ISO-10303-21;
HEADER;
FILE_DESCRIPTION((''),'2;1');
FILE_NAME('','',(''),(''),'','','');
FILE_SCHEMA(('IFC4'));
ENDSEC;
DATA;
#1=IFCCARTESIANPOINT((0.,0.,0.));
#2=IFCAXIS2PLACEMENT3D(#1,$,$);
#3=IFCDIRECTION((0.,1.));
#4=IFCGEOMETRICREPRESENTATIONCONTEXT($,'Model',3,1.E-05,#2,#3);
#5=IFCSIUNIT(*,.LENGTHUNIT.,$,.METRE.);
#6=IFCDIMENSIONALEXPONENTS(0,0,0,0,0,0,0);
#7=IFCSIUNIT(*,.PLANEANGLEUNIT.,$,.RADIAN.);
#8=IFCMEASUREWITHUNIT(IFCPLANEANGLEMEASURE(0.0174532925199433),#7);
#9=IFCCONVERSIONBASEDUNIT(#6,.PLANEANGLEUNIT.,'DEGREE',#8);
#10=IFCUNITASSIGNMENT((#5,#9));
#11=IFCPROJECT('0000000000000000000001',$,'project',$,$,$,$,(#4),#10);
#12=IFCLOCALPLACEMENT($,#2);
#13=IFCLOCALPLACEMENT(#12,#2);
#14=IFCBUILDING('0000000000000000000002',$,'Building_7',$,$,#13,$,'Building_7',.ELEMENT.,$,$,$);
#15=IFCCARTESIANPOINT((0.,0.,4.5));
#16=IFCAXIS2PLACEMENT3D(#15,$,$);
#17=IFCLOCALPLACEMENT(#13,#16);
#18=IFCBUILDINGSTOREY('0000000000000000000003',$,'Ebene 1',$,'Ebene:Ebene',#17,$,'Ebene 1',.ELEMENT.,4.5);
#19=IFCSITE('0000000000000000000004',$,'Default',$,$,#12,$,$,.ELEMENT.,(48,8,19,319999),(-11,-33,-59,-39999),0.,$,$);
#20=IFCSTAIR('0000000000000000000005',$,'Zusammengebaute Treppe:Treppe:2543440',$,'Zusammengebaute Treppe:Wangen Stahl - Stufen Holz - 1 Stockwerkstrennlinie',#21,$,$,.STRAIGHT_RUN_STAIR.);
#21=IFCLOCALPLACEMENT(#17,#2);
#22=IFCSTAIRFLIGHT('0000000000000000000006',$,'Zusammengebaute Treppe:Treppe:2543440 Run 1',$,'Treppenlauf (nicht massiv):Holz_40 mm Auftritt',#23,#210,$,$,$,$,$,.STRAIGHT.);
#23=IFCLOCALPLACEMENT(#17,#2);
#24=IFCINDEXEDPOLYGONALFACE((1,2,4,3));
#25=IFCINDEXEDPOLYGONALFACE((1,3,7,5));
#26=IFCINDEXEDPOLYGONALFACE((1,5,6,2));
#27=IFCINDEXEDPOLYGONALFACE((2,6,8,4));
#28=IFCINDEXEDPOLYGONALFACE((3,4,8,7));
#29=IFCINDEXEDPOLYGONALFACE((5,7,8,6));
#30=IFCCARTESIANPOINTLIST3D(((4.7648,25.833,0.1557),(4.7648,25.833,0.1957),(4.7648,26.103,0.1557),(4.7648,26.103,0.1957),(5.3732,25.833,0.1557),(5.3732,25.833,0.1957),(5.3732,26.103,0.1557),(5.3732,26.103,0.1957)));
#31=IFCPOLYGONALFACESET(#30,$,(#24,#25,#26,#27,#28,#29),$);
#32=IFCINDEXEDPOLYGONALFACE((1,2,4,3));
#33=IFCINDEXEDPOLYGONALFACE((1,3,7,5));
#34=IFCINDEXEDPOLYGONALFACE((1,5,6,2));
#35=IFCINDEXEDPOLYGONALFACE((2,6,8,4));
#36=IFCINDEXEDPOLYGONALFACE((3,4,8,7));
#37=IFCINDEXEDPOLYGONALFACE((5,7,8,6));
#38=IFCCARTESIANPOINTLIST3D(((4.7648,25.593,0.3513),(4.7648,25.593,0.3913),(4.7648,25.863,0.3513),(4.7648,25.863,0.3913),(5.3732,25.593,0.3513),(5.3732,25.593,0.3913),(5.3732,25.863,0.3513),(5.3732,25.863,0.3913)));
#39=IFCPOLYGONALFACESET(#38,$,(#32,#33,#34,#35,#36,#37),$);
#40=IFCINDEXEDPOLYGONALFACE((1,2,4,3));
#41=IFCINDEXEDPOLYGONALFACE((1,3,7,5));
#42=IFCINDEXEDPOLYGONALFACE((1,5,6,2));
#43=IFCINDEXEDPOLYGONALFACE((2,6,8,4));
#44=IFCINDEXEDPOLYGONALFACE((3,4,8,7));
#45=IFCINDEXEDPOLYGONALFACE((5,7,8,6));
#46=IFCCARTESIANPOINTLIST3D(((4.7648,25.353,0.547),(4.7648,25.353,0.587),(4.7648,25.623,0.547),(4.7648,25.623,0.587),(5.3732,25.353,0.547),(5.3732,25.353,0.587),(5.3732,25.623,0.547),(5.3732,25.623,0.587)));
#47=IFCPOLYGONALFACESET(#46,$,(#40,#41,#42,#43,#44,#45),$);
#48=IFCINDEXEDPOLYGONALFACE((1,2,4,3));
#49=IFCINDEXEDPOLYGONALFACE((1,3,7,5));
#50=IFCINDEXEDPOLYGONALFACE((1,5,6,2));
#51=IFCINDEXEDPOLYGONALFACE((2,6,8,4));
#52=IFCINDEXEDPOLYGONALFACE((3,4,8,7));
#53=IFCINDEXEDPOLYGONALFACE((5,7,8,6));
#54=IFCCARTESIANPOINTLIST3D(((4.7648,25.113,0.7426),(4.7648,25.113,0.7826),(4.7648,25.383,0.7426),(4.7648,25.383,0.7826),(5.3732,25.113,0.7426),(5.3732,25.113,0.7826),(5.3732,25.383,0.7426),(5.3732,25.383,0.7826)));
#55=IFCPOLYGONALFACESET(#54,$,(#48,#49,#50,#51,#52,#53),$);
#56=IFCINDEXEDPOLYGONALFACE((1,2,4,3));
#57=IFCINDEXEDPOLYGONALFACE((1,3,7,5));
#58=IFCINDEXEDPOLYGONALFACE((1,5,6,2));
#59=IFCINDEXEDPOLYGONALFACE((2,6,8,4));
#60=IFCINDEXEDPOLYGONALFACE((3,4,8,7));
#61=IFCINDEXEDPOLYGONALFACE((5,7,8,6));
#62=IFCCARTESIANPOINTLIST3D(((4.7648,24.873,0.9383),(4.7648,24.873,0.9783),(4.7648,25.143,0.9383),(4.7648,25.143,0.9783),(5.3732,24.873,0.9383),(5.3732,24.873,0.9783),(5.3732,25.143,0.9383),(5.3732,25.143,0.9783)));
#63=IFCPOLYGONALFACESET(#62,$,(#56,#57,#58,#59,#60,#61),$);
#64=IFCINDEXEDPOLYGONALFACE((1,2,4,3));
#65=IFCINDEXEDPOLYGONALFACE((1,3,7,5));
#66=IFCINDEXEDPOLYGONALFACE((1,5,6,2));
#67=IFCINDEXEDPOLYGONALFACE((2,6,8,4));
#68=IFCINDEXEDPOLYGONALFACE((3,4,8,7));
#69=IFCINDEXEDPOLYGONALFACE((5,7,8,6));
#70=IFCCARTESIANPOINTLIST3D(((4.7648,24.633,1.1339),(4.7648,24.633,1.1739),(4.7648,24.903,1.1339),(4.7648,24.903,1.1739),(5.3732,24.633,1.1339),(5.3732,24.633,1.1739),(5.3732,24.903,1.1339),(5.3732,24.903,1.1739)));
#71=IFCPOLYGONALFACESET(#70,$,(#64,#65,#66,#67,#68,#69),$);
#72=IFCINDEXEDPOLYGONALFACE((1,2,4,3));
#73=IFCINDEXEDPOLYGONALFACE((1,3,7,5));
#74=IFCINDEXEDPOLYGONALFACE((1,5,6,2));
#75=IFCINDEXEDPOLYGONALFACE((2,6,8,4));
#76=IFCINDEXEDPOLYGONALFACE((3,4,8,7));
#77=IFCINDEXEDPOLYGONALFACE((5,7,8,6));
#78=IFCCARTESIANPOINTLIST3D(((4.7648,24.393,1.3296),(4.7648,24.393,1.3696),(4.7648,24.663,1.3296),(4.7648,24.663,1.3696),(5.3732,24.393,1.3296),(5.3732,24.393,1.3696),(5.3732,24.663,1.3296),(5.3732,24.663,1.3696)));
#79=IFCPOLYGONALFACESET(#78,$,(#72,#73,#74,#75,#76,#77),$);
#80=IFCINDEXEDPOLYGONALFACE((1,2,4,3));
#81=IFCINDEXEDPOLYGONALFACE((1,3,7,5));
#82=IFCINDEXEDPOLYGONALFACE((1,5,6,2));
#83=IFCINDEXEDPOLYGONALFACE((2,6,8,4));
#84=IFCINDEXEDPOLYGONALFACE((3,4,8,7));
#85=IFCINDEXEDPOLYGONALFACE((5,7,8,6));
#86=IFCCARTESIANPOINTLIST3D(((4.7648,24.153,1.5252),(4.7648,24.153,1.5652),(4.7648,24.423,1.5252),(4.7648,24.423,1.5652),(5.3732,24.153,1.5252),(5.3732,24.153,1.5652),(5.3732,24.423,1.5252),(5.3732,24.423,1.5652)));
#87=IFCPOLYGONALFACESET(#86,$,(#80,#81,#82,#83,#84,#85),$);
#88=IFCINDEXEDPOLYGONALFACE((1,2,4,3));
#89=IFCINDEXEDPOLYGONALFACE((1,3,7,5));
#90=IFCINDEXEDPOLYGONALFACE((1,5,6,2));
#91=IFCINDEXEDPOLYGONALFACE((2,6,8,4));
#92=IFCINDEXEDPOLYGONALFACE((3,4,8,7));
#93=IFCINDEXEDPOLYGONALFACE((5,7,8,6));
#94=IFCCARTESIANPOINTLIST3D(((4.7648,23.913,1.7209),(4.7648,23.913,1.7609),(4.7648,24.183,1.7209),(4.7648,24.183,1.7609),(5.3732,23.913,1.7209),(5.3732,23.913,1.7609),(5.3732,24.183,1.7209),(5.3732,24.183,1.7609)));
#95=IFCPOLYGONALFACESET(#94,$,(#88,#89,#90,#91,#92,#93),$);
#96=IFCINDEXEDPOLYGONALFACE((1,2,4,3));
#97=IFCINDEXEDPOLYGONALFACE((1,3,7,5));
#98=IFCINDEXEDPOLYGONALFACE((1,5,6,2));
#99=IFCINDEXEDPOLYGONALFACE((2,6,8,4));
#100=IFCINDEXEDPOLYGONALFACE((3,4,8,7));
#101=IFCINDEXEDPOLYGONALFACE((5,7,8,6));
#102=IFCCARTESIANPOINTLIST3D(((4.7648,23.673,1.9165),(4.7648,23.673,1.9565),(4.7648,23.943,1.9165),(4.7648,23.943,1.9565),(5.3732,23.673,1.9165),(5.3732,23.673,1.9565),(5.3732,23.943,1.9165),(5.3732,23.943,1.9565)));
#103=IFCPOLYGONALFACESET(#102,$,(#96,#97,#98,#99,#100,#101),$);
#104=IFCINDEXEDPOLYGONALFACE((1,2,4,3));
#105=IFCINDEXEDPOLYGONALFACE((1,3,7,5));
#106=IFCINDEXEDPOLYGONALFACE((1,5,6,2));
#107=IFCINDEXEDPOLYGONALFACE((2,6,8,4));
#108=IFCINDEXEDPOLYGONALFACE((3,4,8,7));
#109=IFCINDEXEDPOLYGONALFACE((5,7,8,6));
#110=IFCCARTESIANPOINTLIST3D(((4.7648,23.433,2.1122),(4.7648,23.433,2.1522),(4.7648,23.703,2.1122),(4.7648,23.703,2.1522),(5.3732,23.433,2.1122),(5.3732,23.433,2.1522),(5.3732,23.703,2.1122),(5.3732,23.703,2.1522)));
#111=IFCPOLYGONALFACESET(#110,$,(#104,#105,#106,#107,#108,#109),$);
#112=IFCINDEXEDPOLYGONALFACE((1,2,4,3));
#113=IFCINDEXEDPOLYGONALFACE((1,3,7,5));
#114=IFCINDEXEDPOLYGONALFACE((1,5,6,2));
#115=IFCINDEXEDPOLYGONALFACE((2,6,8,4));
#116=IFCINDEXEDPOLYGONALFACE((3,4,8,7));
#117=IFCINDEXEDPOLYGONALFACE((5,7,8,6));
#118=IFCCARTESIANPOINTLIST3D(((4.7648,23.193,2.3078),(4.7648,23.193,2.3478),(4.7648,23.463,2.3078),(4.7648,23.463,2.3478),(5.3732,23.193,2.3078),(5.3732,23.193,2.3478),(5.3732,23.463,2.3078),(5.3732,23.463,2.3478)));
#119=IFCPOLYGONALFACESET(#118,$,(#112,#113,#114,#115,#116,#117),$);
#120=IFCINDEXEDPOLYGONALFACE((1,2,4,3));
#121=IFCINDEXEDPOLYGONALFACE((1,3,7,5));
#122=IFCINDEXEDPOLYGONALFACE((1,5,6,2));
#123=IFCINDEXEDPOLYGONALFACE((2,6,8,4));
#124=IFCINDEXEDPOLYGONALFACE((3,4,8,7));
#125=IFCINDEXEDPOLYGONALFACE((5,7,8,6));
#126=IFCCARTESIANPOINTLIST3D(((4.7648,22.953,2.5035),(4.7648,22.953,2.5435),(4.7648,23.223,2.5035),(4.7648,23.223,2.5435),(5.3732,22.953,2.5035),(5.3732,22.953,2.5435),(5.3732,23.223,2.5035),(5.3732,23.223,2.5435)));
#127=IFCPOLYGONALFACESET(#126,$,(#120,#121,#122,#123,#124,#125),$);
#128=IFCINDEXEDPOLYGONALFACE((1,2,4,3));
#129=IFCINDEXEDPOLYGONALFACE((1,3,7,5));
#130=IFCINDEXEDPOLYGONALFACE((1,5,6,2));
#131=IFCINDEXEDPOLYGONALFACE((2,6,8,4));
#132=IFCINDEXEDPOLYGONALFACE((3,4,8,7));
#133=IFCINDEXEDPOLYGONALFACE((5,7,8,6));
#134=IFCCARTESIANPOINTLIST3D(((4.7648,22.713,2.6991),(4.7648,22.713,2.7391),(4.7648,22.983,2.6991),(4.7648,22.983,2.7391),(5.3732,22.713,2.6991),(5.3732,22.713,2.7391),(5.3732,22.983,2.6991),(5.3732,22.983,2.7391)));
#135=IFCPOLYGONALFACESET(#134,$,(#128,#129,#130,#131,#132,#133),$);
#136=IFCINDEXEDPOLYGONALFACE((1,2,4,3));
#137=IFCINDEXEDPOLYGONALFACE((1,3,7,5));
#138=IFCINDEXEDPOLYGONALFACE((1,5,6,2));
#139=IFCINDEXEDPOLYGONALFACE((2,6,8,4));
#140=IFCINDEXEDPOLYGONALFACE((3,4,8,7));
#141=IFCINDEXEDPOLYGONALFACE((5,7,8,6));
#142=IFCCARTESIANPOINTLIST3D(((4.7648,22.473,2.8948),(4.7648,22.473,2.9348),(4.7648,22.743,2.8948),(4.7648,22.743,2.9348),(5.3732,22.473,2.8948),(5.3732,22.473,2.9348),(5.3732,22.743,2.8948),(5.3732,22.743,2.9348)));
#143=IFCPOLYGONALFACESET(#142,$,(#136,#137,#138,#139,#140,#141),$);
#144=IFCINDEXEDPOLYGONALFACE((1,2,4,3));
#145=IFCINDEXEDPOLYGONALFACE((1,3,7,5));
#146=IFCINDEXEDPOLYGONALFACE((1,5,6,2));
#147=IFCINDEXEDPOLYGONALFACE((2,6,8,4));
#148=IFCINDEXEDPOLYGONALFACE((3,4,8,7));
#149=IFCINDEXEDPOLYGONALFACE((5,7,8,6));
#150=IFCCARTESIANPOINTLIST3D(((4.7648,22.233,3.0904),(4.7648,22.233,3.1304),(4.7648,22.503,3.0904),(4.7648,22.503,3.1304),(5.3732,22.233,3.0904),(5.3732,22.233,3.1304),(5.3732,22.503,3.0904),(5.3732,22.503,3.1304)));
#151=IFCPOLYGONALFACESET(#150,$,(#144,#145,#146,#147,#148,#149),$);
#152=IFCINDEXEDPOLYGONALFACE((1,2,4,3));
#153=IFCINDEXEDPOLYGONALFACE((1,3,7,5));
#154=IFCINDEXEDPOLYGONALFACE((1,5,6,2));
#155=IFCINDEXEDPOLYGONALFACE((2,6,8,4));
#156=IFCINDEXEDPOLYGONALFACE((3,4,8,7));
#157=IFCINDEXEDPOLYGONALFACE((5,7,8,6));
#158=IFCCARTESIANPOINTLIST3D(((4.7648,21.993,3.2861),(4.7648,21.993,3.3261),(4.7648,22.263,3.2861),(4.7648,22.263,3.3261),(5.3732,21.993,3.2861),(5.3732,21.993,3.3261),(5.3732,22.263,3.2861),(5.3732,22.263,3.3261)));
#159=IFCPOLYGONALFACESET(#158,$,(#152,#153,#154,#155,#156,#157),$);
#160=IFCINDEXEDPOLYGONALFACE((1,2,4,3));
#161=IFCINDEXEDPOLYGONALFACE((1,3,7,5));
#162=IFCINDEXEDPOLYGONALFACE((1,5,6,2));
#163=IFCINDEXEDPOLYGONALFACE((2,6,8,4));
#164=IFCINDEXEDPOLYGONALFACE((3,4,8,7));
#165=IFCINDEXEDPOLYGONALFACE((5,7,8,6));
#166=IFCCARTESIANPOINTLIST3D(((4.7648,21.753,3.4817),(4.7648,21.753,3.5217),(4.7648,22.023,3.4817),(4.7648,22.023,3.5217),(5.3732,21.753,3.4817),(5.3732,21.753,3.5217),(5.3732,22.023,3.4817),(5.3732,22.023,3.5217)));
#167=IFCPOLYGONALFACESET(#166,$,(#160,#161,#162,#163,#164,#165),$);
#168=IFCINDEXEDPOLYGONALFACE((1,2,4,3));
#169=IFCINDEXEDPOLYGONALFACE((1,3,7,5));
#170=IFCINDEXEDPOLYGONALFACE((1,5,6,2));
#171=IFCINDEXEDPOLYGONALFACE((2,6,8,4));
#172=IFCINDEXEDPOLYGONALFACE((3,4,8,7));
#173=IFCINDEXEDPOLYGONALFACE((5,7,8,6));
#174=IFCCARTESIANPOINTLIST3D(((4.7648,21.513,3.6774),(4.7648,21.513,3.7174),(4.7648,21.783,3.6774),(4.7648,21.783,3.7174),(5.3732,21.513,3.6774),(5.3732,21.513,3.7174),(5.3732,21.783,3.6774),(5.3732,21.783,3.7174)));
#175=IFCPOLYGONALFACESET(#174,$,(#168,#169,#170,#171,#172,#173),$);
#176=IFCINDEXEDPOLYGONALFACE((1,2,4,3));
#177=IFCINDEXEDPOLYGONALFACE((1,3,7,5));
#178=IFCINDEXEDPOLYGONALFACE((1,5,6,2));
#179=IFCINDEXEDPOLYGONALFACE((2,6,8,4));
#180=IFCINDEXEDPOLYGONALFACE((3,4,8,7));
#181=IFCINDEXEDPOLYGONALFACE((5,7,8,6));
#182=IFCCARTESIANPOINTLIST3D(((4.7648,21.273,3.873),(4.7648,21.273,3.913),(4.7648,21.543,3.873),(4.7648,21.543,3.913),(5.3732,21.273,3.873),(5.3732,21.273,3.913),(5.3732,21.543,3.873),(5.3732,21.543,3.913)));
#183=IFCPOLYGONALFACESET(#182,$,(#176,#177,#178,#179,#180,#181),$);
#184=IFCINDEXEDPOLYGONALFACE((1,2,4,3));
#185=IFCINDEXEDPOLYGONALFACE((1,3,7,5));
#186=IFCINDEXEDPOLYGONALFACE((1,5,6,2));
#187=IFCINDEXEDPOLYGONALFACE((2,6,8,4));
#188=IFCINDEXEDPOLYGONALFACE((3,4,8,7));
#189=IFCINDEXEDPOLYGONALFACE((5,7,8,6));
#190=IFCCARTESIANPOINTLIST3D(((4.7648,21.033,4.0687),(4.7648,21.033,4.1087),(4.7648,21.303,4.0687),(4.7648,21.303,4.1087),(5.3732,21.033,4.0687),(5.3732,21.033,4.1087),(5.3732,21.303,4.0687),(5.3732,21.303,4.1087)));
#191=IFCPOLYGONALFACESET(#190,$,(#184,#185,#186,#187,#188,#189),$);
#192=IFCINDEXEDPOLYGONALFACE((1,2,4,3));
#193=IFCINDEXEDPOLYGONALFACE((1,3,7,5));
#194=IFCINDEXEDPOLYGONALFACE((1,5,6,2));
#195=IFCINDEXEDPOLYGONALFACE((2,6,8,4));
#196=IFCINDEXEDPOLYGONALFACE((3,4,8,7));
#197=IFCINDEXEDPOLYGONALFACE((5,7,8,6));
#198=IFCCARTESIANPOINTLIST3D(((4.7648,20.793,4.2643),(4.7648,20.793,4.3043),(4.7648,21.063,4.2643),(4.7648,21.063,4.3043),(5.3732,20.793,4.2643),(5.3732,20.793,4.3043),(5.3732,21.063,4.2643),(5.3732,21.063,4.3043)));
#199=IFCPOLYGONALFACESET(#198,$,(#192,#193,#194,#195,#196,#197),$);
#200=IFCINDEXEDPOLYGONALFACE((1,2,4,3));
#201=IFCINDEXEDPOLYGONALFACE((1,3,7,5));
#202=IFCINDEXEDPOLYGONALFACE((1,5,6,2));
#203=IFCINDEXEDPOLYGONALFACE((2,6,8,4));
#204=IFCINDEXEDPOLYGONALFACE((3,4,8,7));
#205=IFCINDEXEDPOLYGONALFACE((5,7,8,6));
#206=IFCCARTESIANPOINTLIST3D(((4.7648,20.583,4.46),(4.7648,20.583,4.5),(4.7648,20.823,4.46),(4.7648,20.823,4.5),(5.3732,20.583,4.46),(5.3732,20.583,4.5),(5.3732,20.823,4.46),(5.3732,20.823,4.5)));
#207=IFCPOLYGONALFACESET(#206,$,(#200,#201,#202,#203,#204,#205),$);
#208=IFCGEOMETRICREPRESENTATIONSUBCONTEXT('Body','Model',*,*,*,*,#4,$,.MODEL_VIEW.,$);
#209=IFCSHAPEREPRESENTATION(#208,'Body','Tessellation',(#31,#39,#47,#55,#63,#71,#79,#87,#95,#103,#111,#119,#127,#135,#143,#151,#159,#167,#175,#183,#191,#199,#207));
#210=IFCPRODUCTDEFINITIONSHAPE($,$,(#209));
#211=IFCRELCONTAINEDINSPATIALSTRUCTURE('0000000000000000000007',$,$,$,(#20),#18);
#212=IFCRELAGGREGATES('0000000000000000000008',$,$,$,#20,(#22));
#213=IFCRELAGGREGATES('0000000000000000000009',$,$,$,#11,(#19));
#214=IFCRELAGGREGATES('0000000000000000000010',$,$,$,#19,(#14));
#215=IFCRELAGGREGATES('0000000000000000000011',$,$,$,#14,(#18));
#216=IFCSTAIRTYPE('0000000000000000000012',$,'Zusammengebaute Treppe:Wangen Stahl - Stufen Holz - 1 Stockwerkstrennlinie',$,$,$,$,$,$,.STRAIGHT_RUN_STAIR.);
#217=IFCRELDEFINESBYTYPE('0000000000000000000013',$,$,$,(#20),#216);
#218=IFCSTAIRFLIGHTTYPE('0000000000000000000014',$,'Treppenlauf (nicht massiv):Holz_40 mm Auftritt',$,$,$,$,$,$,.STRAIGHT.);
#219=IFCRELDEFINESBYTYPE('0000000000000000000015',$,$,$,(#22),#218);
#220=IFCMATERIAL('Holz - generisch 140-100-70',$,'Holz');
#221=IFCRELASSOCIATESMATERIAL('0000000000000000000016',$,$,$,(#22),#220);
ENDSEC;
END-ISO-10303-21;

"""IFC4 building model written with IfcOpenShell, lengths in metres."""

from ifc_helpers import new_model, entity, si_unit, converted_unit, direction, frame, origin, place, context, subcontext, project, spatial, indexed_curve, outline, extrude, material, type_object, element, aggregate, save


model = new_model("IFC4")

# Units and contexts
model_context = context("Model", 3, precision=1e-05, world=origin(), true_north=direction((0.0, 1.0)))
body_context = subcontext(model_context, "Body", "Model", "MODEL_VIEW")
ifc_project = project(units=[si_unit("LENGTHUNIT", "METRE"), converted_unit("PLANEANGLEUNIT", "DEGREE", entity("IfcPlaneAngleMeasure", 0.0174532925199433), si_unit("PLANEANGLEUNIT", "RADIAN"), dimensions=[0, 0, 0, 0, 0, 0, 0])], contexts=[model_context])

# Site, building, storey
site_placement = place(None, origin())
site = spatial("IfcSite", under=ifc_project, at=site_placement, Name="Default", CompositionType="ELEMENT", RefLatitude=(48, 8, 19, 319999), RefLongitude=(-11, -33, -59, -39999), RefElevation=0.0)
building_placement = place(site_placement, origin())
building = spatial("IfcBuilding", under=site, at=building_placement, Name="Building_7", LongName="Building_7", CompositionType="ELEMENT")
storey_placement = place(building_placement, frame((0.0, 0.0, 4.5)))
storey = spatial("IfcBuildingStorey", under=building, at=storey_placement, Name="Ebene 1", ObjectType="Ebene:Ebene", LongName="Ebene 1", CompositionType="ELEMENT", Elevation=4.5)

# Stair
stair_type = type_object("IfcStairType", Name="Zusammengebaute Treppe:Wangen Stahl - Stufen Holz - 1 Stockwerkstrennlinie", PredefinedType="STRAIGHT_RUN_STAIR")
stair_placement = place(storey_placement, origin())
stair = element("IfcStair", 1, at=stair_placement, inside=storey, type_object=stair_type, Name="Zusammengebaute Treppe:Treppe:2543440", ObjectType="Zusammengebaute Treppe:Wangen Stahl - Stufen Holz - 1 Stockwerkstrennlinie", PredefinedType="STRAIGHT_RUN_STAIR")

# Stair flight
ifc_material_1 = material(Name="Holz - generisch 140-100-70", Category="Holz")
stair_flight_type = type_object("IfcStairFlightType", Name="Treppenlauf (nicht massiv):Holz_40 mm Auftritt", PredefinedType="STRAIGHT")
stair_flight_placement = place(stair_placement, origin())
stair_flight = element("IfcStairFlight", 2, at=stair_flight_placement, type_object=stair_flight_type, material=ifc_material_1, Name="Zusammengebaute Treppe:Treppe:2543440 Run 1", ObjectType="Treppenlauf (nicht massiv):Holz_40 mm Auftritt", PredefinedType="STRAIGHT", context=body_context, shape_type="SweptSolid", body=[
    extrude(outline(indexed_curve([(-0.135, -0.3042), (0.135, -0.3042), (0.135, 0.3042), (-0.135, 0.3042), (-0.135, -0.3042)], self_intersect=False)), frame((5.069, 25.968, 0.1557), z_axis=(0.0, 0.0, 1.0), x_axis=(0.0, 1.0, 0.0)), (0.0, 0.0, 1.0), 0.04),
    extrude(outline(indexed_curve([(-0.135, -0.3042), (0.135, -0.3042), (0.135, 0.3042), (-0.135, 0.3042), (-0.135, -0.3042)], self_intersect=False)), frame((5.069, 25.728, 0.3513), z_axis=(0.0, 0.0, 1.0), x_axis=(0.0, 1.0, 0.0)), (0.0, 0.0, 1.0), 0.04),
    extrude(outline(indexed_curve([(-0.135, -0.3042), (0.135, -0.3042), (0.135, 0.3042), (-0.135, 0.3042), (-0.135, -0.3042)], self_intersect=False)), frame((5.069, 25.488, 0.547), z_axis=(0.0, 0.0, 1.0), x_axis=(0.0, 1.0, 0.0)), (0.0, 0.0, 1.0), 0.04),
    extrude(outline(indexed_curve([(-0.135, -0.3042), (0.135, -0.3042), (0.135, 0.3042), (-0.135, 0.3042), (-0.135, -0.3042)], self_intersect=False)), frame((5.069, 25.248, 0.7426), z_axis=(0.0, 0.0, 1.0), x_axis=(0.0, 1.0, 0.0)), (0.0, 0.0, 1.0), 0.04),
    extrude(outline(indexed_curve([(-0.135, -0.3042), (0.135, -0.3042), (0.135, 0.3042), (-0.135, 0.3042), (-0.135, -0.3042)], self_intersect=False)), frame((5.069, 25.008, 0.9383), z_axis=(0.0, 0.0, 1.0), x_axis=(0.0, 1.0, 0.0)), (0.0, 0.0, 1.0), 0.04),
    extrude(outline(indexed_curve([(-0.135, -0.3042), (0.135, -0.3042), (0.135, 0.3042), (-0.135, 0.3042), (-0.135, -0.3042)], self_intersect=False)), frame((5.069, 24.768, 1.1339), z_axis=(0.0, 0.0, 1.0), x_axis=(0.0, 1.0, 0.0)), (0.0, 0.0, 1.0), 0.04),
    extrude(outline(indexed_curve([(-0.135, -0.3042), (0.135, -0.3042), (0.135, 0.3042), (-0.135, 0.3042), (-0.135, -0.3042)], self_intersect=False)), frame((5.069, 24.528, 1.3296), z_axis=(0.0, 0.0, 1.0), x_axis=(0.0, 1.0, 0.0)), (0.0, 0.0, 1.0), 0.04),
    extrude(outline(indexed_curve([(-0.135, -0.3042), (0.135, -0.3042), (0.135, 0.3042), (-0.135, 0.3042), (-0.135, -0.3042)], self_intersect=False)), frame((5.069, 24.288, 1.5252), z_axis=(0.0, 0.0, 1.0), x_axis=(0.0, 1.0, 0.0)), (0.0, 0.0, 1.0), 0.04),
    extrude(outline(indexed_curve([(-0.135, -0.3042), (0.135, -0.3042), (0.135, 0.3042), (-0.135, 0.3042), (-0.135, -0.3042)], self_intersect=False)), frame((5.069, 24.048, 1.7209), z_axis=(0.0, 0.0, 1.0), x_axis=(0.0, 1.0, 0.0)), (0.0, 0.0, 1.0), 0.04),
    extrude(outline(indexed_curve([(-0.135, -0.3042), (0.135, -0.3042), (0.135, 0.3042), (-0.135, 0.3042), (-0.135, -0.3042)], self_intersect=False)), frame((5.069, 23.808, 1.9165), z_axis=(0.0, 0.0, 1.0), x_axis=(0.0, 1.0, 0.0)), (0.0, 0.0, 1.0), 0.04),
    extrude(outline(indexed_curve([(-0.135, -0.3042), (0.135, -0.3042), (0.135, 0.3042), (-0.135, 0.3042), (-0.135, -0.3042)], self_intersect=False)), frame((5.069, 23.568, 2.1122), z_axis=(0.0, 0.0, 1.0), x_axis=(0.0, 1.0, 0.0)), (0.0, 0.0, 1.0), 0.04),
    extrude(outline(indexed_curve([(-0.135, -0.3042), (0.135, -0.3042), (0.135, 0.3042), (-0.135, 0.3042), (-0.135, -0.3042)], self_intersect=False)), frame((5.069, 23.328, 2.3078), z_axis=(0.0, 0.0, 1.0), x_axis=(0.0, 1.0, 0.0)), (0.0, 0.0, 1.0), 0.04),
    extrude(outline(indexed_curve([(-0.135, -0.3042), (0.135, -0.3042), (0.135, 0.3042), (-0.135, 0.3042), (-0.135, -0.3042)], self_intersect=False)), frame((5.069, 23.088, 2.5035), z_axis=(0.0, 0.0, 1.0), x_axis=(0.0, 1.0, 0.0)), (0.0, 0.0, 1.0), 0.04),
    extrude(outline(indexed_curve([(-0.135, -0.3042), (0.135, -0.3042), (0.135, 0.3042), (-0.135, 0.3042), (-0.135, -0.3042)], self_intersect=False)), frame((5.069, 22.848, 2.6991), z_axis=(0.0, 0.0, 1.0), x_axis=(0.0, 1.0, 0.0)), (0.0, 0.0, 1.0), 0.04),
    extrude(outline(indexed_curve([(-0.135, -0.3042), (0.135, -0.3042), (0.135, 0.3042), (-0.135, 0.3042), (-0.135, -0.3042)], self_intersect=False)), frame((5.069, 22.608, 2.8948), z_axis=(0.0, 0.0, 1.0), x_axis=(0.0, 1.0, 0.0)), (0.0, 0.0, 1.0), 0.04),
    extrude(outline(indexed_curve([(-0.135, -0.3042), (0.135, -0.3042), (0.135, 0.3042), (-0.135, 0.3042), (-0.135, -0.3042)], self_intersect=False)), frame((5.069, 22.368, 3.0904), z_axis=(0.0, 0.0, 1.0), x_axis=(0.0, 1.0, 0.0)), (0.0, 0.0, 1.0), 0.04),
    extrude(outline(indexed_curve([(-0.135, -0.3042), (0.135, -0.3042), (0.135, 0.3042), (-0.135, 0.3042), (-0.135, -0.3042)], self_intersect=False)), frame((5.069, 22.128, 3.2861), z_axis=(0.0, 0.0, 1.0), x_axis=(0.0, 1.0, 0.0)), (0.0, 0.0, 1.0), 0.04),
    extrude(outline(indexed_curve([(-0.135, -0.3042), (0.135, -0.3042), (0.135, 0.3042), (-0.135, 0.3042), (-0.135, -0.3042)], self_intersect=False)), frame((5.069, 21.888, 3.4817), z_axis=(0.0, 0.0, 1.0), x_axis=(0.0, 1.0, 0.0)), (0.0, 0.0, 1.0), 0.04),
    extrude(outline(indexed_curve([(-0.135, -0.3042), (0.135, -0.3042), (0.135, 0.3042), (-0.135, 0.3042), (-0.135, -0.3042)], self_intersect=False)), frame((5.069, 21.648, 3.6774), z_axis=(0.0, 0.0, 1.0), x_axis=(0.0, 1.0, 0.0)), (0.0, 0.0, 1.0), 0.04),
    extrude(outline(indexed_curve([(-0.135, -0.3042), (0.135, -0.3042), (0.135, 0.3042), (-0.135, 0.3042), (-0.135, -0.3042)], self_intersect=False)), frame((5.069, 21.408, 3.873), z_axis=(0.0, 0.0, 1.0), x_axis=(0.0, 1.0, 0.0)), (0.0, 0.0, 1.0), 0.04),
    extrude(outline(indexed_curve([(-0.135, -0.3042), (0.135, -0.3042), (0.135, 0.3042), (-0.135, 0.3042), (-0.135, -0.3042)], self_intersect=False)), frame((5.069, 21.168, 4.0687), z_axis=(0.0, 0.0, 1.0), x_axis=(0.0, 1.0, 0.0)), (0.0, 0.0, 1.0), 0.04),
    extrude(outline(indexed_curve([(-0.135, -0.3042), (0.135, -0.3042), (0.135, 0.3042), (-0.135, 0.3042), (-0.135, -0.3042)], self_intersect=False)), frame((5.069, 20.928, 4.2643), z_axis=(0.0, 0.0, 1.0), x_axis=(0.0, 1.0, 0.0)), (0.0, 0.0, 1.0), 0.04),
    extrude(outline(indexed_curve([(-0.12, -0.3042), (0.12, -0.3042), (0.12, 0.3042), (-0.12, 0.3042), (-0.12, -0.3042)], self_intersect=False)), frame((5.069, 20.703, 4.46), z_axis=(0.0, 0.0, 1.0), x_axis=(0.0, 1.0, 0.0)), (0.0, 0.0, 1.0), 0.04),
])
aggregate(stair, [stair_flight])

save(model, "model.ifc")
